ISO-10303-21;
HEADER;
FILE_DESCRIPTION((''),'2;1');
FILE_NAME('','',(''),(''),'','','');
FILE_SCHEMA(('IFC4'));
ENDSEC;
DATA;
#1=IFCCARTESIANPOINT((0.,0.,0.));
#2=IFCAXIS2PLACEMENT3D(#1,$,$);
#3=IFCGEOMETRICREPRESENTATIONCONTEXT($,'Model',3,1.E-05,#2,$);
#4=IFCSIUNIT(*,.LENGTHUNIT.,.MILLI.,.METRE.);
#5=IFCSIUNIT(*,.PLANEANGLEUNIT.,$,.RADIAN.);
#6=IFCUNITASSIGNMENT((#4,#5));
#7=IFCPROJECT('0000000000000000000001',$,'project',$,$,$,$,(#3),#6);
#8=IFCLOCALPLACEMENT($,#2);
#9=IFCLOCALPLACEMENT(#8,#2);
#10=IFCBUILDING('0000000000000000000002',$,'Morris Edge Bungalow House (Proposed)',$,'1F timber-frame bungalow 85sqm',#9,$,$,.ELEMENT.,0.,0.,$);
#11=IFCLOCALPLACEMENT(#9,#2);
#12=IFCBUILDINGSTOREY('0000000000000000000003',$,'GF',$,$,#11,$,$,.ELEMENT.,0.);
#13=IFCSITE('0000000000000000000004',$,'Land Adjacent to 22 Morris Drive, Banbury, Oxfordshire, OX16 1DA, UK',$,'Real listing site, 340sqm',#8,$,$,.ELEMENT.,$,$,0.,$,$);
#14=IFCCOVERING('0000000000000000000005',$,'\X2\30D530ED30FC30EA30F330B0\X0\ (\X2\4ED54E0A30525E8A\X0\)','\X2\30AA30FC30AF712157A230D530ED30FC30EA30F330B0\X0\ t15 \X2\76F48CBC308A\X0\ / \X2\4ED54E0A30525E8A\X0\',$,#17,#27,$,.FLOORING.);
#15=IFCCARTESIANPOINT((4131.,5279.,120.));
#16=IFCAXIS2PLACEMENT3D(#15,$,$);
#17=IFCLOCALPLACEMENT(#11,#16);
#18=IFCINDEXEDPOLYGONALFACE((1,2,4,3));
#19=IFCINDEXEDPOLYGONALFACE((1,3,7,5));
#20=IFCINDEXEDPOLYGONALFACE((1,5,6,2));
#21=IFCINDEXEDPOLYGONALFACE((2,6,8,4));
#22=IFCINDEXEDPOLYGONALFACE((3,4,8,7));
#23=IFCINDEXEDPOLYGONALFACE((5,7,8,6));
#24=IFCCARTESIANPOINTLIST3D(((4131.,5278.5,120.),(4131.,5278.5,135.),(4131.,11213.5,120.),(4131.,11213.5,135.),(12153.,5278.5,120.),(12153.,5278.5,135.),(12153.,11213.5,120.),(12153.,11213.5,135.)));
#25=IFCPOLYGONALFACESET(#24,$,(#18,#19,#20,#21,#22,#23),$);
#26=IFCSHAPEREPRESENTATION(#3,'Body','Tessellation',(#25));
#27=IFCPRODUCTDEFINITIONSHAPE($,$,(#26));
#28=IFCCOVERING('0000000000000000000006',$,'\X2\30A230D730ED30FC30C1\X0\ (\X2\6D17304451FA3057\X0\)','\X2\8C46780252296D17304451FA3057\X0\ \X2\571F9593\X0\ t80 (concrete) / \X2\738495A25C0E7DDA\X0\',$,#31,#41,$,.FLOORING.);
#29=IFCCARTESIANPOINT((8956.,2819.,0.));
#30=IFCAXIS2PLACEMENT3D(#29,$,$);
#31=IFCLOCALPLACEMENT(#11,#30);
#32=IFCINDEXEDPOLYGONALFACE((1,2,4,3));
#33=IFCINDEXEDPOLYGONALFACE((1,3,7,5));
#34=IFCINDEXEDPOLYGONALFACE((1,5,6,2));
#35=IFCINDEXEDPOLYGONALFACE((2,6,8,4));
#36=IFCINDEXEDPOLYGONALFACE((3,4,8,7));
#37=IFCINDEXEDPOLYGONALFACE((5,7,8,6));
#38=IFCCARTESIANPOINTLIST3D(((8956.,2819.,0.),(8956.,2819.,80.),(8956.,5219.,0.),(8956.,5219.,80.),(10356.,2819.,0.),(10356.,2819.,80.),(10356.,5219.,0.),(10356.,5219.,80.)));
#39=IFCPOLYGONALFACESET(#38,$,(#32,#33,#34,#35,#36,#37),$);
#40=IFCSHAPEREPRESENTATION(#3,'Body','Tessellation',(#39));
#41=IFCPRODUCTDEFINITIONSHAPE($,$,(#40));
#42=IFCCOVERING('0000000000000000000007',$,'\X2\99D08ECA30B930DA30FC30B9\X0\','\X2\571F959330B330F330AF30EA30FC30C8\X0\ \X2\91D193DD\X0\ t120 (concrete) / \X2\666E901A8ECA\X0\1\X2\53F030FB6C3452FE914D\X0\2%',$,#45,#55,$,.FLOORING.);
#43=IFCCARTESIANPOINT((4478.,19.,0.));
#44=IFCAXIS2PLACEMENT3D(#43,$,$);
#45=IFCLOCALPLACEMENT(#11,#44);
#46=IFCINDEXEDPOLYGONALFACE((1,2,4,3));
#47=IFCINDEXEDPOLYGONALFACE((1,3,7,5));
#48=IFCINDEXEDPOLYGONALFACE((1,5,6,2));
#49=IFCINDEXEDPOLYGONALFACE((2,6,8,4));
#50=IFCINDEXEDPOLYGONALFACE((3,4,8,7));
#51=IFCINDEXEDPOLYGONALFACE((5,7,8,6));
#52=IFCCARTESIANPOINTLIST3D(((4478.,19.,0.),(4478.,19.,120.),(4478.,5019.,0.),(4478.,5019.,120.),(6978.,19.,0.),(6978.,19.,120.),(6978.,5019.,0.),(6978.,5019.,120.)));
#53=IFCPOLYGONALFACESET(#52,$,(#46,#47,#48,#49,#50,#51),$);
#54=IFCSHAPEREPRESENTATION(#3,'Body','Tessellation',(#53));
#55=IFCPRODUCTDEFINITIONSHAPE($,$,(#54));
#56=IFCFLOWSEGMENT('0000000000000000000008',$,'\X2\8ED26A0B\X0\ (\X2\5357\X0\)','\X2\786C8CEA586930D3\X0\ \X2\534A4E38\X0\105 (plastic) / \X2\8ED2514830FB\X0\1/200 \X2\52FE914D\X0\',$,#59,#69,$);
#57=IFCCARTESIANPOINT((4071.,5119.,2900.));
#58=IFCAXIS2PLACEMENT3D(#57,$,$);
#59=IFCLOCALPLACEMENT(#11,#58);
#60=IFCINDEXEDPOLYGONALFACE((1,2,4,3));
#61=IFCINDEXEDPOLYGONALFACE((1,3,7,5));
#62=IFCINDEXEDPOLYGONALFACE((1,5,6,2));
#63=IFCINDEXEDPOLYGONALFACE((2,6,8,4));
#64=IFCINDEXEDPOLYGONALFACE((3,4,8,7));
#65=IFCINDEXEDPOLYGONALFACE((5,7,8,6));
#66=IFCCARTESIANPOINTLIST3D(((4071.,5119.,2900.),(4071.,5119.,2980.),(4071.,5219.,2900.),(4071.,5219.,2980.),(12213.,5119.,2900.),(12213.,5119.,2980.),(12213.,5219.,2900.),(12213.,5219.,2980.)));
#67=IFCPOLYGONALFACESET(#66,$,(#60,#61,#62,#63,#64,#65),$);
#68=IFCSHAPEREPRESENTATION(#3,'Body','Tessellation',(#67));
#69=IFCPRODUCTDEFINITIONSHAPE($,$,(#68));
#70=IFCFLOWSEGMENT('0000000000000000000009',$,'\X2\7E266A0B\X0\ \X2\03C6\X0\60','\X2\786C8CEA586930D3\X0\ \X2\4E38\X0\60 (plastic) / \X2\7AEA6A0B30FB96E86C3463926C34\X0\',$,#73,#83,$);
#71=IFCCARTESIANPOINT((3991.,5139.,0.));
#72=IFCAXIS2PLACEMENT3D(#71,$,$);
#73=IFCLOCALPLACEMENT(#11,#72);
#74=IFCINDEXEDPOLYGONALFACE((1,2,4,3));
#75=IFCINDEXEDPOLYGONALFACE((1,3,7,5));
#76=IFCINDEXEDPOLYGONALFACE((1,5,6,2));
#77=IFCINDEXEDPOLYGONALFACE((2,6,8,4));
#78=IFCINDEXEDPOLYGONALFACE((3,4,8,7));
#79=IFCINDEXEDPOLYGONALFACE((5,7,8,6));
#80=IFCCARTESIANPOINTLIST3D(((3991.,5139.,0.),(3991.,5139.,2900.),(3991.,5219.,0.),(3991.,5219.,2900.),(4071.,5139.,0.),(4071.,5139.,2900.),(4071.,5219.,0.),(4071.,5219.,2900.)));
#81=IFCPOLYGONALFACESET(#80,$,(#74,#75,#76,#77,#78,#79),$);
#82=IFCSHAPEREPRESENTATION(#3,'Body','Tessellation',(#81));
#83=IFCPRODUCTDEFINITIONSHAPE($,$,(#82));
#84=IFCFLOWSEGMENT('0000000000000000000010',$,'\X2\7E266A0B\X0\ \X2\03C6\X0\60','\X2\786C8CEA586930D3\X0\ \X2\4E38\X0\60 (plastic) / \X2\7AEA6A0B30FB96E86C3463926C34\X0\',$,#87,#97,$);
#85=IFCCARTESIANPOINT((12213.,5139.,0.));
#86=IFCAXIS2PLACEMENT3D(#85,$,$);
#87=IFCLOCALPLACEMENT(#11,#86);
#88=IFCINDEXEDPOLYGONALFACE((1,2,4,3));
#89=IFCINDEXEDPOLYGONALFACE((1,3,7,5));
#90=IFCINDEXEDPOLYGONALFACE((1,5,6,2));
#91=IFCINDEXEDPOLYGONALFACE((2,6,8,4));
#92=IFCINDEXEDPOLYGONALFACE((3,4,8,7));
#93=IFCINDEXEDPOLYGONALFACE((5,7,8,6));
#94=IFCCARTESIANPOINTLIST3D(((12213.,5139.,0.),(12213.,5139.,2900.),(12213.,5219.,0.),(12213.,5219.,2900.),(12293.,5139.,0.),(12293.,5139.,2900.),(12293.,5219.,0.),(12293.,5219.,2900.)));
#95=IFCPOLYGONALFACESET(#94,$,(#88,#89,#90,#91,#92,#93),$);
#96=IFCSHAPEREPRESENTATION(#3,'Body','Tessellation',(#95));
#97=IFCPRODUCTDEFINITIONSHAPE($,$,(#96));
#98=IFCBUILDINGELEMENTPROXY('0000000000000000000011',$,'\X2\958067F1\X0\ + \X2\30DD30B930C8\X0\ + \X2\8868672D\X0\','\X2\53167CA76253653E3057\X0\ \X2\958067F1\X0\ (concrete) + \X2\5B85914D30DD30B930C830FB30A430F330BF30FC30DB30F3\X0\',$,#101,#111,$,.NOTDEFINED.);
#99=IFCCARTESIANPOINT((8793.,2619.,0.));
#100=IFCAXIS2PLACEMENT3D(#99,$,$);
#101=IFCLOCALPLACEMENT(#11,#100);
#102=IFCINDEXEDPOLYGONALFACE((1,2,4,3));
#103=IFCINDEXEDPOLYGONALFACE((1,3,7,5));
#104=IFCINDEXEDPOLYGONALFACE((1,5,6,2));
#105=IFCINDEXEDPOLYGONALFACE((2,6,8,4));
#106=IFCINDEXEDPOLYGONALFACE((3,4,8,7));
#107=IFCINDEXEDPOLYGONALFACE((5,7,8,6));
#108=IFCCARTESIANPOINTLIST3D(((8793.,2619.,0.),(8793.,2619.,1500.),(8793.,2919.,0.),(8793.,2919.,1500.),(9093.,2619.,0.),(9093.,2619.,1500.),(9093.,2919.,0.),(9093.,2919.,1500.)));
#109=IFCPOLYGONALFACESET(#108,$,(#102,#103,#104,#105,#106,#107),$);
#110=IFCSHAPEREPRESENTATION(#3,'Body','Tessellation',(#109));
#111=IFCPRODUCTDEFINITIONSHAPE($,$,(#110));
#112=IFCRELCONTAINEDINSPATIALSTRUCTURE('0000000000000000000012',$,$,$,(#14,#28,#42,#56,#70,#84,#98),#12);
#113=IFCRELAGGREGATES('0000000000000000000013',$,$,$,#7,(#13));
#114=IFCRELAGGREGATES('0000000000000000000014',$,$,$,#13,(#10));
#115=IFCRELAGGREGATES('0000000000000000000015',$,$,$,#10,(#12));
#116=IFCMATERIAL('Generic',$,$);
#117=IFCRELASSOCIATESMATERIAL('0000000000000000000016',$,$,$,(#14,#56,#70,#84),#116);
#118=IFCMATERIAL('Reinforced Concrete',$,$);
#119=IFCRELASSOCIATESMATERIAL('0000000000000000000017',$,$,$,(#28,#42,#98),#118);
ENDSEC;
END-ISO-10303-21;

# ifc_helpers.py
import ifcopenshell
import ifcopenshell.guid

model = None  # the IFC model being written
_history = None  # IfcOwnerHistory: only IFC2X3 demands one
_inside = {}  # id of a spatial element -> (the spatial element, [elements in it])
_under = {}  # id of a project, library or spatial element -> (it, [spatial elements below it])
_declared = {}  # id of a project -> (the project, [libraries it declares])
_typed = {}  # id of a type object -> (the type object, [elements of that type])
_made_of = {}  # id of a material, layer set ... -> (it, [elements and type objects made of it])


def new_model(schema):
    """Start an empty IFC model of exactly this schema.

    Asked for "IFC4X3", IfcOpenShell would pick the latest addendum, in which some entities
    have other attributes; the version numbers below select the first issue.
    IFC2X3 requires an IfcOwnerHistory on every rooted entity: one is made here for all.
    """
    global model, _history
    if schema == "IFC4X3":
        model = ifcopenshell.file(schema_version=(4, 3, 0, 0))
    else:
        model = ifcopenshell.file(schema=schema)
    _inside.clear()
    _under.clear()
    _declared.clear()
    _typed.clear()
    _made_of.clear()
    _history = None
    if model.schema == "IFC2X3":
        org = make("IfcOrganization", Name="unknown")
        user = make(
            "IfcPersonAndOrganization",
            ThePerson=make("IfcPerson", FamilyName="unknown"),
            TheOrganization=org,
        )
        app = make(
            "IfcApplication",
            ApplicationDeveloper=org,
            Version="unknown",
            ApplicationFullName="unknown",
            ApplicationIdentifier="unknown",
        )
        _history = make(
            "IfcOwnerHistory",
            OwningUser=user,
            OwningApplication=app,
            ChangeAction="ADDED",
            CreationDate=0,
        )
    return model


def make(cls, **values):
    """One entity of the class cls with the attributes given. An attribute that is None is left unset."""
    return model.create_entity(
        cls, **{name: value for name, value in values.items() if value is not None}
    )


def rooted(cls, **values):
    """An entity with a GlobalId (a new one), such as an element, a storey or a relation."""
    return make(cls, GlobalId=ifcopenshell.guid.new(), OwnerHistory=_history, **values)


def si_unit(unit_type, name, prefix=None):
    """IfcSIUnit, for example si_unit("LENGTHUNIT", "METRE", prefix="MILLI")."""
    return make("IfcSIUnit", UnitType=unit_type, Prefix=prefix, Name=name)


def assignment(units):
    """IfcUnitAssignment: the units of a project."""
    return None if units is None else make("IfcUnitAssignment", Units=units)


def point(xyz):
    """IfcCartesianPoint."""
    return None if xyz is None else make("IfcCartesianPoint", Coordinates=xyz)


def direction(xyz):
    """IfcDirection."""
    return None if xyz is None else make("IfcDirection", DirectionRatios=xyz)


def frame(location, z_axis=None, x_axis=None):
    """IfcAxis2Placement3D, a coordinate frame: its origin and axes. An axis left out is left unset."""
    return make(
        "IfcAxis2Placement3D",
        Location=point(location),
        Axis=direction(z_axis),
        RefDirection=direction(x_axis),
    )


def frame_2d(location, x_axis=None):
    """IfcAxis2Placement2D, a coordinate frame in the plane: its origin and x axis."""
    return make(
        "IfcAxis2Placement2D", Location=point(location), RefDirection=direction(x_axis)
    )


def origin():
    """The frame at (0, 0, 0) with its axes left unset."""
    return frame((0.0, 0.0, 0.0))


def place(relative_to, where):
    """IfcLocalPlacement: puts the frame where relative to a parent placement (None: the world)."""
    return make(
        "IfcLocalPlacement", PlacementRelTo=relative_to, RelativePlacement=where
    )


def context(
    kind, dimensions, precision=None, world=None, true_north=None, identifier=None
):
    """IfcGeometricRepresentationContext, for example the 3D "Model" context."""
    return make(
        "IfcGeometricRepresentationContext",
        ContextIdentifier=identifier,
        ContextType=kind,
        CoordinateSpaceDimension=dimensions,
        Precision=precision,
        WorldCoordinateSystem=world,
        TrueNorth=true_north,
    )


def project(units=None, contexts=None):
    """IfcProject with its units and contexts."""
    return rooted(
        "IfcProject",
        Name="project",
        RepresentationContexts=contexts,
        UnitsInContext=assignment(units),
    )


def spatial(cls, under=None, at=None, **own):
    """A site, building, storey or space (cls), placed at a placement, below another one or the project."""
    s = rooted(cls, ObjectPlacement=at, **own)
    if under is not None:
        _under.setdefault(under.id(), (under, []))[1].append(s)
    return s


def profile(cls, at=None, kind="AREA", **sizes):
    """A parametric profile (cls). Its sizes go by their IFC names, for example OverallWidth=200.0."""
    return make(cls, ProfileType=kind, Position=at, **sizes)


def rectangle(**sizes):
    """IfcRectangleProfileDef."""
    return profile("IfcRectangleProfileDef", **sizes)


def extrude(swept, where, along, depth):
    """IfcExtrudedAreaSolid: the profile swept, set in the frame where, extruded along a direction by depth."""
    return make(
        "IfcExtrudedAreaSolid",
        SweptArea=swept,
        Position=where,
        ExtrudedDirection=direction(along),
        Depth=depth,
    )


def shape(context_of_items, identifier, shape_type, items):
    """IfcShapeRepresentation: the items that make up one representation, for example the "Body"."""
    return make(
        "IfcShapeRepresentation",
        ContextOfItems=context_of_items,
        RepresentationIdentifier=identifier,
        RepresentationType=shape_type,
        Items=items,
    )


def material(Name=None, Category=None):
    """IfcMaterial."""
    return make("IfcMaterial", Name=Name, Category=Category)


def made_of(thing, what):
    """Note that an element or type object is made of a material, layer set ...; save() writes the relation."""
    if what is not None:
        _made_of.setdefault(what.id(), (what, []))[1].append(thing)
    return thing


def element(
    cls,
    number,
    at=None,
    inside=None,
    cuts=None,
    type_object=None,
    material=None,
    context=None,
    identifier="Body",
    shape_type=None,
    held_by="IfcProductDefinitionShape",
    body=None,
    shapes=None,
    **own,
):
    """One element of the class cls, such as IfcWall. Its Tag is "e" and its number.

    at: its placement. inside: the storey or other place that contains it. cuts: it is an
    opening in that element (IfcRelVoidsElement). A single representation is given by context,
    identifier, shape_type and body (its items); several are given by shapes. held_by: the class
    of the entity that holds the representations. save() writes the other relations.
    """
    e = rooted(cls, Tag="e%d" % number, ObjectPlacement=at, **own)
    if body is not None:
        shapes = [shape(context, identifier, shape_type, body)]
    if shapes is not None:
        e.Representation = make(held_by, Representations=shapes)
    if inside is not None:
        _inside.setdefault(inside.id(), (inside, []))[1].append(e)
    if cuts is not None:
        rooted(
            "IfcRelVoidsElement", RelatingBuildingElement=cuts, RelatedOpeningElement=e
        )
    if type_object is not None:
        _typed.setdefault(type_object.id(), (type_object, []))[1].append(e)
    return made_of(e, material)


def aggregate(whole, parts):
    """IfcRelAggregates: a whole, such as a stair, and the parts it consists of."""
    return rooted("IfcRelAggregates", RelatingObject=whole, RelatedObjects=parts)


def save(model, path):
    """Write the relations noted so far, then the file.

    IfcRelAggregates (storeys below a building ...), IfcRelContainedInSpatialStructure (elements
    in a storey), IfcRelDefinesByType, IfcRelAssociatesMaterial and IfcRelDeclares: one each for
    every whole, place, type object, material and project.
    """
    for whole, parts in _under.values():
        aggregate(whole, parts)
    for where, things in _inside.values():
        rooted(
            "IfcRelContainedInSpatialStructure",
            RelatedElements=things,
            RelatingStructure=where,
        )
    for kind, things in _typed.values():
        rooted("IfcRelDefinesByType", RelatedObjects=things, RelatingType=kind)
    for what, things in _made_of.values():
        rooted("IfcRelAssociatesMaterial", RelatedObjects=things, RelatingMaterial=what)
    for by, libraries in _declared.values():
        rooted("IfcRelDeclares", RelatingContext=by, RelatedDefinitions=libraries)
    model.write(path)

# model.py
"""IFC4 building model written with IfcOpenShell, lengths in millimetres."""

from ifc_helpers import new_model, si_unit, frame, frame_2d, origin, place, context, project, spatial, rectangle, extrude, material, element, save


model = new_model("IFC4")

# Units and contexts
model_context = context("Model", 3, precision=1e-05, world=origin())
ifc_project = project(units=[si_unit("LENGTHUNIT", "METRE", prefix="MILLI"), si_unit("PLANEANGLEUNIT", "RADIAN")], contexts=[model_context])

# Site, building, storey
site_placement = place(None, origin())
site = spatial("IfcSite", under=ifc_project, at=site_placement, Name="Land Adjacent to 22 Morris Drive, Banbury, Oxfordshire, OX16 1DA, UK", ObjectType="Real listing site, 340sqm", CompositionType="ELEMENT", RefElevation=0.0)
building_placement = place(site_placement, origin())
building = spatial("IfcBuilding", under=site, at=building_placement, Name="Morris Edge Bungalow House (Proposed)", ObjectType="1F timber-frame bungalow 85sqm", CompositionType="ELEMENT", ElevationOfRefHeight=0.0, ElevationOfTerrain=0.0)
storey_placement = place(building_placement, origin())
storey = spatial("IfcBuildingStorey", under=building, at=storey_placement, Name="GF", CompositionType="ELEMENT", Elevation=0.0)

# Shared definitions
ifc_material_1 = material(Name="Reinforced Concrete")

# Coverings
ifc_material_2 = material(Name="Generic")
covering_1_placement = place(storey_placement, frame((4131.0, 5279.0, 120.0)))
element("IfcCovering", 1, at=covering_1_placement, inside=storey, material=ifc_material_2, Name="フローリング (仕上げ床)", Description="オーク無垢フローリング t15 直貼り / 仕上げ床", PredefinedType="FLOORING", context=model_context, shape_type="SweptSolid", body=[
    extrude(rectangle(XDim=8022.0, YDim=5935.0, at=frame_2d((4011.0, 2967.0))), frame((4131.0, 5279.0, 120.0)), (0.0, 0.0, 1.0), 15.0),
])
covering_2_placement = place(storey_placement, frame((8956.0, 2819.0, 0.0)))
element("IfcCovering", 2, at=covering_2_placement, inside=storey, material=ifc_material_1, Name="アプローチ (洗い出し)", Description="豆砂利洗い出し 土間 t80 (concrete) / 玄関導線", PredefinedType="FLOORING", context=model_context, shape_type="SweptSolid", body=[
    extrude(rectangle(XDim=1400.0, YDim=2400.0, at=frame_2d((700.0, 1200.0))), frame((8956.0, 2819.0, 0.0)), (0.0, 0.0, 1.0), 80.0),
])
covering_3_placement = place(storey_placement, frame((4478.0, 19.0, 0.0)))
element("IfcCovering", 3, at=covering_3_placement, inside=storey, material=ifc_material_1, Name="駐車スペース", Description="土間コンクリート 金鏝 t120 (concrete) / 普通車1台・水勾配2%", PredefinedType="FLOORING", context=model_context, shape_type="SweptSolid", body=[
    extrude(rectangle(XDim=2500.0, YDim=5000.0, at=frame_2d((1250.0, 2500.0))), frame((4478.0, 19.0, 0.0)), (0.0, 0.0, 1.0), 120.0),
])

# Flow segments
flow_segment_1_placement = place(storey_placement, frame((4071.0, 5119.0, 2900.0)))
element("IfcFlowSegment", 4, at=flow_segment_1_placement, inside=storey, material=ifc_material_2, Name="軒樋 (南)", Description="硬質塩ビ 半丸105 (plastic) / 軒先・1/200 勾配", context=model_context, shape_type="SweptSolid", body=[
    extrude(rectangle(XDim=8142.0, YDim=100.0, at=frame_2d((4071.0, 50.0))), frame((4071.0, 5119.0, 2900.0)), (0.0, 0.0, 1.0), 80.0),
])
flow_segment_2_placement = place(storey_placement, frame((3991.0, 5139.0, 0.0)))
element("IfcFlowSegment", 5, at=flow_segment_2_placement, inside=storey, material=ifc_material_2, Name="縦樋 φ60", Description="硬質塩ビ 丸60 (plastic) / 竪樋・雨水排水", context=model_context, shape_type="SweptSolid", body=[
    extrude(rectangle(XDim=80.0, YDim=80.0, at=frame_2d((40.0, 40.0))), frame((3991.0, 5139.0, 0.0)), (0.0, 0.0, 1.0), 2900.0),
])
flow_segment_3_placement = place(storey_placement, frame((12213.0, 5139.0, 0.0)))
element("IfcFlowSegment", 6, at=flow_segment_3_placement, inside=storey, material=ifc_material_2, Name="縦樋 φ60", Description="硬質塩ビ 丸60 (plastic) / 竪樋・雨水排水", context=model_context, shape_type="SweptSolid", body=[
    extrude(rectangle(XDim=80.0, YDim=80.0, at=frame_2d((40.0, 40.0))), frame((12213.0, 5139.0, 0.0)), (0.0, 0.0, 1.0), 2900.0),
])

# Building element proxy
proxy_placement = place(storey_placement, frame((8793.0, 2619.0, 0.0)))
element("IfcBuildingElementProxy", 7, at=proxy_placement, inside=storey, material=ifc_material_1, Name="門柱 + ポスト + 表札", Description="化粧打放し 門柱 (concrete) + 宅配ポスト・インターホン", PredefinedType="NOTDEFINED", context=model_context, shape_type="SweptSolid", body=[
    extrude(rectangle(XDim=300.0, YDim=300.0, at=frame_2d((150.0, 150.0))), frame((8793.0, 2619.0, 0.0)), (0.0, 0.0, 1.0), 1500.0),
])

save(model, "model.ifc")
